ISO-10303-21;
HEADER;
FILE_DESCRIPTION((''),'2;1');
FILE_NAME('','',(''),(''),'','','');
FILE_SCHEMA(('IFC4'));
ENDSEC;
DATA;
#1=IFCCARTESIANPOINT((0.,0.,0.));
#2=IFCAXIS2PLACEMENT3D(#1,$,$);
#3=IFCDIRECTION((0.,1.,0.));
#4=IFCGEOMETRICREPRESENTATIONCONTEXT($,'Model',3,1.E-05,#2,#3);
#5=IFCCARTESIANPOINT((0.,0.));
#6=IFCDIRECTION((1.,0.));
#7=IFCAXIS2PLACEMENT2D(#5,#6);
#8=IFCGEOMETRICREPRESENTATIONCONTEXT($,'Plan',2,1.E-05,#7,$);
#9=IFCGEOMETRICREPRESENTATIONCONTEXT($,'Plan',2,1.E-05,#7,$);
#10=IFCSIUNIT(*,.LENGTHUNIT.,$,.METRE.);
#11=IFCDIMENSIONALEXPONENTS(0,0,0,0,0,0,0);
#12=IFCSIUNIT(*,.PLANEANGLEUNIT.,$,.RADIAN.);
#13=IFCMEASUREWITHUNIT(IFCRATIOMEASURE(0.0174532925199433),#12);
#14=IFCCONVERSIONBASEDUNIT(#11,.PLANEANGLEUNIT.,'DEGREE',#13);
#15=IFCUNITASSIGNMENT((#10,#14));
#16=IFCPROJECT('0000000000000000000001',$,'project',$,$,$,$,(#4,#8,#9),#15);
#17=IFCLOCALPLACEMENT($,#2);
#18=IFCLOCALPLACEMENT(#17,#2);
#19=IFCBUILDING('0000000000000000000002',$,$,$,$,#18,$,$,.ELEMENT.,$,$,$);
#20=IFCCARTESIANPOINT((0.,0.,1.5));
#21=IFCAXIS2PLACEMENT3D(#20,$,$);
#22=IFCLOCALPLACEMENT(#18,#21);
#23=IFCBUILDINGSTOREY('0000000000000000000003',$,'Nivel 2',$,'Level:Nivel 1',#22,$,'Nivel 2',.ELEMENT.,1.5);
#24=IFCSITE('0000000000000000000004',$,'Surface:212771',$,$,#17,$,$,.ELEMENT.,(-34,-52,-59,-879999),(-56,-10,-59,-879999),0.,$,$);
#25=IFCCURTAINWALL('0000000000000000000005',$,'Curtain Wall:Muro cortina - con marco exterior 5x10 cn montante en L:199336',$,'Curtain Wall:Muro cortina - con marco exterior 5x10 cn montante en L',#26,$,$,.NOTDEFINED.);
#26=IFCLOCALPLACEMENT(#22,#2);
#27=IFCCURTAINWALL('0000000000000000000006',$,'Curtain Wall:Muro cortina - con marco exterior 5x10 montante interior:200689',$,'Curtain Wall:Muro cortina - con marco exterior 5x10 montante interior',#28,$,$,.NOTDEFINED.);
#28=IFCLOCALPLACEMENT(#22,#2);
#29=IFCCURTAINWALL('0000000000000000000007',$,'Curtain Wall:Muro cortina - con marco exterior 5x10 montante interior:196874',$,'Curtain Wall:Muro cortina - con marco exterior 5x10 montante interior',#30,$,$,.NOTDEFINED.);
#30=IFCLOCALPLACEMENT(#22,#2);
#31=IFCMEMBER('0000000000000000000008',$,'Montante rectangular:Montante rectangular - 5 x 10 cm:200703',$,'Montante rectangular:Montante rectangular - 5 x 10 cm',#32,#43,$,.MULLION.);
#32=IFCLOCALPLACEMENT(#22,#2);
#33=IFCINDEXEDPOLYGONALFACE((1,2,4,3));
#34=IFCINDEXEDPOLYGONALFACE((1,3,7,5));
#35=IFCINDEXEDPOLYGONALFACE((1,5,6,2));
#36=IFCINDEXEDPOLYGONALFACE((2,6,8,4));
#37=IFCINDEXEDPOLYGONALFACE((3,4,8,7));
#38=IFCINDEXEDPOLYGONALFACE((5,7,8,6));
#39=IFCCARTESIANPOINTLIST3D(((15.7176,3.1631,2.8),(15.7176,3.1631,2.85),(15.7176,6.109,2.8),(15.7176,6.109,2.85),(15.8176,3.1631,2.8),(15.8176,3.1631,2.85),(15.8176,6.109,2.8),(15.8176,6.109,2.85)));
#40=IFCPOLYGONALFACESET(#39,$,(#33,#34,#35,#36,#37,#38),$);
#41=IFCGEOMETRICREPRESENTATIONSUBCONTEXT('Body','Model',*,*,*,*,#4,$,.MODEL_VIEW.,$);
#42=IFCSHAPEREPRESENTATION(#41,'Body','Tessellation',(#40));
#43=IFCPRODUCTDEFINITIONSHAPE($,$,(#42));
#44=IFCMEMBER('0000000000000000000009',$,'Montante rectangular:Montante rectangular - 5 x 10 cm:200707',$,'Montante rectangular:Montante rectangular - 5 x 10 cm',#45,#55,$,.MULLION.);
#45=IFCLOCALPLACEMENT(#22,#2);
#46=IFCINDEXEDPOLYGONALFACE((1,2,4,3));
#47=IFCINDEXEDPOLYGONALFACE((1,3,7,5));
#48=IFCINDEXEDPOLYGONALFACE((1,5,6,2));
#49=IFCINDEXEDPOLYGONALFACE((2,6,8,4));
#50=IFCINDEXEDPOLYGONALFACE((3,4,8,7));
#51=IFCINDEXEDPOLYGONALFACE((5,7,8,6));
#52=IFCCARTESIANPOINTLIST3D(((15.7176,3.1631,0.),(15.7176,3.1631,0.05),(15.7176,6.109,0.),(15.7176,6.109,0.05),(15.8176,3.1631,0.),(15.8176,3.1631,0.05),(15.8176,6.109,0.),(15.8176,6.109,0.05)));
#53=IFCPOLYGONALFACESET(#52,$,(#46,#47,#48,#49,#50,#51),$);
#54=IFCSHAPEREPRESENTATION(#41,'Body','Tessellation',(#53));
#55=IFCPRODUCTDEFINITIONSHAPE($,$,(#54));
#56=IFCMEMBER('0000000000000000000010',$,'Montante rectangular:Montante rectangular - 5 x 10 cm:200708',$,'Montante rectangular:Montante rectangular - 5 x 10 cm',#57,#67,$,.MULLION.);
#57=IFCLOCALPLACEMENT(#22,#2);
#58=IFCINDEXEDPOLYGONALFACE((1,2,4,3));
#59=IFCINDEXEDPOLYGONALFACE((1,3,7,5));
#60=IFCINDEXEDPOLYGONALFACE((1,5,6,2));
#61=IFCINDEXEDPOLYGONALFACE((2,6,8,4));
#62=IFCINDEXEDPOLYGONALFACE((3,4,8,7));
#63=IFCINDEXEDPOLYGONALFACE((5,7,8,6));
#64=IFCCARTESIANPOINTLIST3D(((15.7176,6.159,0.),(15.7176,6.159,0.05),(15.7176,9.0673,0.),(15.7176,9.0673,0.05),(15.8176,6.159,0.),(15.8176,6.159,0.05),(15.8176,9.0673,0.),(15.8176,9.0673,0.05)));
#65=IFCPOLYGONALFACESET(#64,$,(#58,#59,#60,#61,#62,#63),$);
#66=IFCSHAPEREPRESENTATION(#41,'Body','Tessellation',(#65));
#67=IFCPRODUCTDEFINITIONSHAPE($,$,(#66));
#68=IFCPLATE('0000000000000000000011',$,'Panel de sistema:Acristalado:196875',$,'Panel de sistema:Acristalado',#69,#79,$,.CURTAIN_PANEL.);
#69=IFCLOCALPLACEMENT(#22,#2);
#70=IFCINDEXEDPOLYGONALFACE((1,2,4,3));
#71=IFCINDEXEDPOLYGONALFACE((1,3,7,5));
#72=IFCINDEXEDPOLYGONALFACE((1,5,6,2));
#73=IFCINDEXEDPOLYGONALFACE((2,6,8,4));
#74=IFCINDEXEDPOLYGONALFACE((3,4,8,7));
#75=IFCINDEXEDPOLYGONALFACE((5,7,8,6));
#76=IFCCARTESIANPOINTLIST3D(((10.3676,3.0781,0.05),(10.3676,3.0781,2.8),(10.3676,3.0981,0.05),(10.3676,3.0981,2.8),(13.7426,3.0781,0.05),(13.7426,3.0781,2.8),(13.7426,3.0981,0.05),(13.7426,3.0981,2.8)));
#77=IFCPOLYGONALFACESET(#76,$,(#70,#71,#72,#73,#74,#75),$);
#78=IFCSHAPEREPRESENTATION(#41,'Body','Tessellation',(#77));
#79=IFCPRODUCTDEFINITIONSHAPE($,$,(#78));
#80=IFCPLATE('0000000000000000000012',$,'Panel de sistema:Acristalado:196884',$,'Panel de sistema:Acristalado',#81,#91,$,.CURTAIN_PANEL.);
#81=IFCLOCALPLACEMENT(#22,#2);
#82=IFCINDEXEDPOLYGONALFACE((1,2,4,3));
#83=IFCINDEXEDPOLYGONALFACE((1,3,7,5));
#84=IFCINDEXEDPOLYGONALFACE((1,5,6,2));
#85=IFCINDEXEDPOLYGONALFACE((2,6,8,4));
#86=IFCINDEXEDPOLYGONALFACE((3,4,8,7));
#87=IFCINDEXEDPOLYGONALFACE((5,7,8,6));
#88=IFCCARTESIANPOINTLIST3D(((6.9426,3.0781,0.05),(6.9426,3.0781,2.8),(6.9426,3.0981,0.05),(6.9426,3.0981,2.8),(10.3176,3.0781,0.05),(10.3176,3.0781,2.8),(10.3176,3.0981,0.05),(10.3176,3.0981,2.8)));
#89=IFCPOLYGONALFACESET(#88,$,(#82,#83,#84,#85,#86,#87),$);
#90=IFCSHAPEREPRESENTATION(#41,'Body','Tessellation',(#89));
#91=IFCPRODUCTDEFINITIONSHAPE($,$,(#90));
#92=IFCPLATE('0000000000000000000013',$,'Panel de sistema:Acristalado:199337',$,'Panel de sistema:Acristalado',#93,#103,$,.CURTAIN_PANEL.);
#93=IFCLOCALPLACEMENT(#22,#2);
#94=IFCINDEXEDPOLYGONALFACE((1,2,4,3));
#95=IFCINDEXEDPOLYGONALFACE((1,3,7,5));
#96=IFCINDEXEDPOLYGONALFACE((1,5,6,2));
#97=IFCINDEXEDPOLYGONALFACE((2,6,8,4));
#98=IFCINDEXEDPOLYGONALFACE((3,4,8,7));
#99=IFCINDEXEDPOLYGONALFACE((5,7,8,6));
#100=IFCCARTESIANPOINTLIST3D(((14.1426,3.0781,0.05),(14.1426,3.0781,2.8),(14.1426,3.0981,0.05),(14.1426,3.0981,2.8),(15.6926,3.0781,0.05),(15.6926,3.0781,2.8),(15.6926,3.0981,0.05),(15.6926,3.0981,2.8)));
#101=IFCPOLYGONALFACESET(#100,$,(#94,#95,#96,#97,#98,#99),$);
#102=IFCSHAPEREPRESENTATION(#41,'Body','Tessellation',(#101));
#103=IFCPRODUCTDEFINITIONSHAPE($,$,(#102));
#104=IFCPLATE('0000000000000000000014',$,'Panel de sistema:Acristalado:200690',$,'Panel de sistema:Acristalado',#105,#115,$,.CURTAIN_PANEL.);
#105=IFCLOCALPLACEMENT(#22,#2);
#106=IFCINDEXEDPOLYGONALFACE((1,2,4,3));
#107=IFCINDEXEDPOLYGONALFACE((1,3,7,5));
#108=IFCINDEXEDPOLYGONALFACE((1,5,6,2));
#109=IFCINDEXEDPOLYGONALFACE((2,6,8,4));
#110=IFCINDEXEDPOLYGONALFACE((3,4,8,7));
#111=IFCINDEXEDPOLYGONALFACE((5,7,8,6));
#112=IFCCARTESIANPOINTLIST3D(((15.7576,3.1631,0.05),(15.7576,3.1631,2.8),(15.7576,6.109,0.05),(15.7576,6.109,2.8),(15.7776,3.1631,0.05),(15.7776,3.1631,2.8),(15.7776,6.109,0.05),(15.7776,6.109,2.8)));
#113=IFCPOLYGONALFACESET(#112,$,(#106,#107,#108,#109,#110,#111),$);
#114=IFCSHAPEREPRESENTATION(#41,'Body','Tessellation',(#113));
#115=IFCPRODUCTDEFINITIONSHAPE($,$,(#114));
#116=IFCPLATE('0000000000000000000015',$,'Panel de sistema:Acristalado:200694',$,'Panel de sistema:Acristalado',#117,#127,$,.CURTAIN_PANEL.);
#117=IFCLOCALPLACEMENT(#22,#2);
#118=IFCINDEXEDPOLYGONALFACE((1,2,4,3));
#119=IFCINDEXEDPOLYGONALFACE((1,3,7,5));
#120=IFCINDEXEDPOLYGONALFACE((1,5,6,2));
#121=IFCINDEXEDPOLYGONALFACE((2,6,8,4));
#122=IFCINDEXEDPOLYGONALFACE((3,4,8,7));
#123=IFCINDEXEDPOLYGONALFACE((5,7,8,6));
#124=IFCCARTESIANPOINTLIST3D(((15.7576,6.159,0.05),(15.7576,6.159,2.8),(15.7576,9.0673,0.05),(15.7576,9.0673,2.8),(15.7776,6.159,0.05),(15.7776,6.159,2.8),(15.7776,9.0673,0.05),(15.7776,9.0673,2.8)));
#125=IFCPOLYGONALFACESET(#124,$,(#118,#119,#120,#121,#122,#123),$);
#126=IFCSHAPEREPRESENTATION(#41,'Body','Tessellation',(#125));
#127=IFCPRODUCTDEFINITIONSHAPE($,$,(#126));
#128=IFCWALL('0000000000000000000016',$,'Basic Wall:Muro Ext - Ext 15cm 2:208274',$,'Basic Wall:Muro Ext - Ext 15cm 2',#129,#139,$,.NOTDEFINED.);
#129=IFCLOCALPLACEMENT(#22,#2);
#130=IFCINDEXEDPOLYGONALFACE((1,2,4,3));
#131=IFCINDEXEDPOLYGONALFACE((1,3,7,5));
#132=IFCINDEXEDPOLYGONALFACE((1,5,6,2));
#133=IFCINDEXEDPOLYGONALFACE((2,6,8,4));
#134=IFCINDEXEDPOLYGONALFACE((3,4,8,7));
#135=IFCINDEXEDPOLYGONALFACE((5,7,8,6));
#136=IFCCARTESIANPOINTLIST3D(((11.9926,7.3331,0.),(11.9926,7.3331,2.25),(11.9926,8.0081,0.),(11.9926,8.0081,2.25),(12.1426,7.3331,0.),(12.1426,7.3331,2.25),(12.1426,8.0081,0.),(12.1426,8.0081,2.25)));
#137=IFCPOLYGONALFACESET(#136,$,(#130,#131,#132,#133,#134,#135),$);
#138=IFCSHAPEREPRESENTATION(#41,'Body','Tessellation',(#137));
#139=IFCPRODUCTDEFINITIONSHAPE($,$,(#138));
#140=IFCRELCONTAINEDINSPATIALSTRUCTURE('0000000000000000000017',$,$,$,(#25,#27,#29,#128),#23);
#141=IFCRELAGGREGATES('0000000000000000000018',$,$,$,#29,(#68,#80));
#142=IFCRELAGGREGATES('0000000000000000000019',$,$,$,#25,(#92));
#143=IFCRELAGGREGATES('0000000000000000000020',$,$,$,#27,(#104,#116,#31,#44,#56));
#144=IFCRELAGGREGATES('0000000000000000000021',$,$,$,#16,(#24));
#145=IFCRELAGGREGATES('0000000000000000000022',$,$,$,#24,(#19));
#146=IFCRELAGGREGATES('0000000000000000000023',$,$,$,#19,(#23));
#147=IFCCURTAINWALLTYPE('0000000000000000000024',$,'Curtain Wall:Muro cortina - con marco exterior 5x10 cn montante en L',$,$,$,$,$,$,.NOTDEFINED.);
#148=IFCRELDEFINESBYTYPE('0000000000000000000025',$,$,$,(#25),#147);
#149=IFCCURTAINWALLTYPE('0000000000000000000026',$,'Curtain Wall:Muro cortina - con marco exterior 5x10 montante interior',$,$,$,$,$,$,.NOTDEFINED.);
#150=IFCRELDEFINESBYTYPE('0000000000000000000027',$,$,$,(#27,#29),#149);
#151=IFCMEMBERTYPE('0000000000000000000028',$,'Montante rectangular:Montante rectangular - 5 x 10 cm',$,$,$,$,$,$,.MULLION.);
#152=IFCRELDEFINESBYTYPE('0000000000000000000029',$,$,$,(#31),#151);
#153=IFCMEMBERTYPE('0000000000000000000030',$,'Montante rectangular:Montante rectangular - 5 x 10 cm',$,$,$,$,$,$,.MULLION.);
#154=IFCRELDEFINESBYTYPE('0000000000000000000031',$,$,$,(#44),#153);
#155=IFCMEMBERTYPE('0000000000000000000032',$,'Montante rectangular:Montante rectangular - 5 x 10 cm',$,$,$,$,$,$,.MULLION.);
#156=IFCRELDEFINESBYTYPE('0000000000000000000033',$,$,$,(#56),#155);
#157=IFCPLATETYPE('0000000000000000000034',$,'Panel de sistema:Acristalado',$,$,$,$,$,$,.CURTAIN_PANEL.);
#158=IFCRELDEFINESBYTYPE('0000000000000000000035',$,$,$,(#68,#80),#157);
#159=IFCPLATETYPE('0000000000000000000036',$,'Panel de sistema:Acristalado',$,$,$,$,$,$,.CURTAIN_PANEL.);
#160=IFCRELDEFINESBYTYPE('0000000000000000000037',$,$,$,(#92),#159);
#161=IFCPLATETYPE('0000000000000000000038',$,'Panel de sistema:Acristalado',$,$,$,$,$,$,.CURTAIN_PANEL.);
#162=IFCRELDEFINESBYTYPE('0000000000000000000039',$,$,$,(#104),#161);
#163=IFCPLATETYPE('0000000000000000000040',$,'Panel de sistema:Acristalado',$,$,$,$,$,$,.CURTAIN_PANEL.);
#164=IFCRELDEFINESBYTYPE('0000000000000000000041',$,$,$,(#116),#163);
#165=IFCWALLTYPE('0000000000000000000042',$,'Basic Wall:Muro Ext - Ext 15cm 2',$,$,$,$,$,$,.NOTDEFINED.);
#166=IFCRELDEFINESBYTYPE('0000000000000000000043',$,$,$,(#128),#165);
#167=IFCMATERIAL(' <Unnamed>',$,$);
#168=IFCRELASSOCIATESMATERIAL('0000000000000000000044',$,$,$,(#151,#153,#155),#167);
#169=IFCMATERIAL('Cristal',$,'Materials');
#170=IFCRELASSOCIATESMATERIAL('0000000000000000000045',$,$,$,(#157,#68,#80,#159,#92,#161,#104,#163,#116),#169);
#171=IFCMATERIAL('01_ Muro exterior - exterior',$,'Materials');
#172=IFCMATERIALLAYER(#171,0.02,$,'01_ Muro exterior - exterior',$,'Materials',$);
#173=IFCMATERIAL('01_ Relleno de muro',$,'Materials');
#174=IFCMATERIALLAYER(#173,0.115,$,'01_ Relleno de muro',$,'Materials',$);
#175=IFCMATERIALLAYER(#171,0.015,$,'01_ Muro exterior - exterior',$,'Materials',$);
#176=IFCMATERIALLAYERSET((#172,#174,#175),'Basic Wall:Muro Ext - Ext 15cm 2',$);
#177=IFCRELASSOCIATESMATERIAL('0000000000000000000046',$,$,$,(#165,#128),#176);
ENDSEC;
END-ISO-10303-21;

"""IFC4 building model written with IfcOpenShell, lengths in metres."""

from ifc_helpers import new_model, entity, si_unit, converted_unit, direction, frame, origin, origin_2d_with_axis, place, context, subcontext, project, spatial, indexed_curve, outline, extrude, shape, source, transform, mapped, material, layer, layer_set, type_object, type_shapes, element, aggregate, save


model = new_model("IFC4")

# Units and contexts
model_context = context("Model", 3, precision=1e-05, world=origin(), true_north=direction((0.0, 1.0, 0.0)))
plan_context_1 = context("Plan", 2, precision=1e-05, world=origin_2d_with_axis())
plan_context_2 = context("Plan", 2, precision=1e-05, world=origin_2d_with_axis())
body_context = subcontext(model_context, "Body", "Model", "MODEL_VIEW")
footprint_context = subcontext(model_context, "FootPrint", "Model", "MODEL_VIEW")
ifc_project = project(units=[si_unit("LENGTHUNIT", "METRE"), converted_unit("PLANEANGLEUNIT", "DEGREE", entity("IfcRatioMeasure", 0.0174532925199433), si_unit("PLANEANGLEUNIT", "RADIAN"), dimensions=[0, 0, 0, 0, 0, 0, 0])], contexts=[model_context, plan_context_1, plan_context_2])

# Site, building, storey
site_placement = place(None, origin())
site = spatial("IfcSite", under=ifc_project, at=site_placement, Name="Surface:212771", CompositionType="ELEMENT", RefLatitude=(-34, -52, -59, -879999), RefLongitude=(-56, -10, -59, -879999), RefElevation=0.0)
building_placement = place(site_placement, origin())
building = spatial("IfcBuilding", under=site, at=building_placement, CompositionType="ELEMENT")
storey_placement = place(building_placement, frame((0.0, 0.0, 1.5)))
storey = spatial("IfcBuildingStorey", under=building, at=storey_placement, Name="Nivel 2", ObjectType="Level:Nivel 1", LongName="Nivel 2", CompositionType="ELEMENT", Elevation=1.5)

# Curtain walls
curtain_wall_type_1 = type_object("IfcCurtainWallType", Name="Curtain Wall:Muro cortina - con marco exterior 5x10 cn montante en L", PredefinedType="NOTDEFINED")
curtain_wall_1_placement = place(storey_placement, frame((0.0, 0.0, -1.5)))
curtain_wall_1 = element("IfcCurtainWall", 1, at=curtain_wall_1_placement, inside=storey, type_object=curtain_wall_type_1, Name="Curtain Wall:Muro cortina - con marco exterior 5x10 cn montante en L:199336", ObjectType="Curtain Wall:Muro cortina - con marco exterior 5x10 cn montante en L", PredefinedType="NOTDEFINED")
ifc_material_1 = material(Name=" <Unnamed>")
curtain_wall_type_2 = type_object("IfcCurtainWallType", Name="Curtain Wall:Muro cortina - con marco exterior 5x10 montante interior", PredefinedType="NOTDEFINED")
curtain_wall_2_placement = place(storey_placement, frame((0.0, 0.0, -1.5)))
curtain_wall_2 = element("IfcCurtainWall", 2, at=curtain_wall_2_placement, inside=storey, type_object=curtain_wall_type_2, Name="Curtain Wall:Muro cortina - con marco exterior 5x10 montante interior:200689", ObjectType="Curtain Wall:Muro cortina - con marco exterior 5x10 montante interior", PredefinedType="NOTDEFINED")

# Curtain wall
curtain_wall_3_placement = place(storey_placement, frame((0.0, 0.0, -1.5)))
curtain_wall_3 = element("IfcCurtainWall", 3, at=curtain_wall_3_placement, inside=storey, type_object=curtain_wall_type_2, Name="Curtain Wall:Muro cortina - con marco exterior 5x10 montante interior:196874", ObjectType="Curtain Wall:Muro cortina - con marco exterior 5x10 montante interior", PredefinedType="NOTDEFINED")

# Members
member_type_1 = type_object("IfcMemberType", Name="Montante rectangular:Montante rectangular - 5 x 10 cm", PredefinedType="MULLION", material=ifc_material_1)
shared_shape_1 = source(origin(), body_context, "Body", "SweptSolid", [
    extrude(outline(indexed_curve([(-0.05, -0.025), (0.05, -0.025), (0.05, 0.025), (-0.05, 0.025), (-0.05, -0.025)], self_intersect=False)), frame((-0.025, 0.0, -2.9458), z_axis=(0.0, 0.0, 1.0), x_axis=(0.0, -1.0, 0.0)), (0.0, 0.0, 1.0), 2.9458),
])
type_shapes(member_type_1, [shared_shape_1])
member_1_placement = place(storey_placement, frame((15.7676, 6.109, 2.85), z_axis=(0.0, 1.0, 0.0), x_axis=(0.0, 0.0, 1.0)))
member_1 = element("IfcMember", 4, at=member_1_placement, type_object=member_type_1, Name="Montante rectangular:Montante rectangular - 5 x 10 cm:200703", ObjectType="Montante rectangular:Montante rectangular - 5 x 10 cm", PredefinedType="MULLION", context=body_context, shape_type="MappedRepresentation", body=[
    mapped(shared_shape_1, transform((0.0, 0.0, 0.0), scale=1.0)),
])
member_type_2 = type_object("IfcMemberType", Name="Montante rectangular:Montante rectangular - 5 x 10 cm", PredefinedType="MULLION", material=ifc_material_1)
shared_shape_2 = source(origin(), body_context, "Body", "SweptSolid", [
    extrude(outline(indexed_curve([(-0.05, -0.025), (0.05, -0.025), (0.05, 0.025), (-0.05, 0.025), (-0.05, -0.025)], self_intersect=False)), frame((-0.025, 0.0, -2.9458), z_axis=(0.0, 0.0, 1.0), x_axis=(0.0, -1.0, 0.0)), (0.0, 0.0, 1.0), 2.9458),
])
type_shapes(member_type_2, [shared_shape_2])
member_2_placement = place(storey_placement, frame((15.7676, 3.1631, 0.0), z_axis=(0.0, -1.0, 0.0), x_axis=(0.0, 0.0, -1.0)))
member_2 = element("IfcMember", 5, at=member_2_placement, type_object=member_type_2, Name="Montante rectangular:Montante rectangular - 5 x 10 cm:200707", ObjectType="Montante rectangular:Montante rectangular - 5 x 10 cm", PredefinedType="MULLION", context=body_context, shape_type="MappedRepresentation", body=[
    mapped(shared_shape_2, transform((0.0, 0.0, 0.0), scale=1.0)),
])
member_type_3 = type_object("IfcMemberType", Name="Montante rectangular:Montante rectangular - 5 x 10 cm", PredefinedType="MULLION", material=ifc_material_1)
shared_shape_3 = source(origin(), body_context, "Body", "SweptSolid", [
    extrude(outline(indexed_curve([(-0.05, -0.025), (0.05, -0.025), (0.05, 0.025), (-0.05, 0.025), (-0.05, -0.025)], self_intersect=False)), frame((-0.025, 0.0, -2.9083), z_axis=(0.0, 0.0, 1.0), x_axis=(0.0, -1.0, 0.0)), (0.0, 0.0, 1.0), 2.9083),
])
type_shapes(member_type_3, [shared_shape_3])
member_3_placement = place(storey_placement, frame((15.7676, 6.159, 0.0), z_axis=(0.0, -1.0, 0.0), x_axis=(0.0, 0.0, -1.0)))
member_3 = element("IfcMember", 6, at=member_3_placement, type_object=member_type_3, Name="Montante rectangular:Montante rectangular - 5 x 10 cm:200708", ObjectType="Montante rectangular:Montante rectangular - 5 x 10 cm", PredefinedType="MULLION", context=body_context, shape_type="MappedRepresentation", body=[
    mapped(shared_shape_3, transform((0.0, 0.0, 0.0), scale=1.0)),
])

# Plates
ifc_material_2 = material(Name="Cristal", Category="Materials")
plate_type_1 = type_object("IfcPlateType", Name="Panel de sistema:Acristalado", PredefinedType="CURTAIN_PANEL", material=ifc_material_2)
shared_shape_4 = source(origin(), body_context, "Body", "SweptSolid", [
    extrude(outline(indexed_curve([(-0.01, -1.6875), (0.01, -1.6875), (0.01, 1.6875), (-0.01, 1.6875), (-0.01, -1.6875)], self_intersect=False)), frame((0.0, 0.0, 0.0), z_axis=(0.0, 0.0, 1.0), x_axis=(0.0, 1.0, 0.0)), (0.0, 0.0, 1.0), 2.75),
])
shared_shape_5 = source(origin(), footprint_context, "FootPrint", "Curve2D", [
    entity("IfcIndexedPolyCurve", entity("IfcCartesianPointList2D", [[1.6875, -0.01], [1.6875, 0.01], [-1.6875, 0.01], [-1.6875, -0.01], [1.6875, -0.01]]), None, False),
])
type_shapes(plate_type_1, [shared_shape_4, shared_shape_5])
plate_1_placement = place(curtain_wall_3_placement, frame((12.0551, 3.0881, 1.55), z_axis=(0.0, 0.0, 1.0), x_axis=(-1.0, 0.0, 0.0)))
plate_1 = element("IfcPlate", 7, at=plate_1_placement, type_object=plate_type_1, material=ifc_material_2, Name="Panel de sistema:Acristalado:196875", ObjectType="Panel de sistema:Acristalado", PredefinedType="CURTAIN_PANEL", shapes=[
    shape(body_context, "Body", "MappedRepresentation", [mapped(shared_shape_4, transform((0.0, 0.0, 0.0), scale=1.0))]),
    shape(body_context, "Body", "MappedRepresentation", [mapped(shared_shape_5, transform((0.0, 0.0, 0.0), scale=1.0))]),
])
plate_2_placement = place(curtain_wall_3_placement, frame((8.6301, 3.0881, 1.55), z_axis=(0.0, 0.0, 1.0), x_axis=(-1.0, 0.0, 0.0)))
plate_2 = element("IfcPlate", 8, at=plate_2_placement, type_object=plate_type_1, material=ifc_material_2, Name="Panel de sistema:Acristalado:196884", ObjectType="Panel de sistema:Acristalado", PredefinedType="CURTAIN_PANEL", shapes=[
    shape(body_context, "Body", "MappedRepresentation", [mapped(shared_shape_4, transform((0.0, 0.0, 0.0), scale=1.0))]),
    shape(body_context, "Body", "MappedRepresentation", [mapped(shared_shape_5, transform((0.0, 0.0, 0.0), scale=1.0))]),
])
aggregate(curtain_wall_3, [plate_1, plate_2])
plate_type_2 = type_object("IfcPlateType", Name="Panel de sistema:Acristalado", PredefinedType="CURTAIN_PANEL", material=ifc_material_2)
shared_shape_6 = source(origin(), body_context, "Body", "SweptSolid", [
    extrude(outline(indexed_curve([(-0.01, -0.775), (0.01, -0.775), (0.01, 0.775), (-0.01, 0.775), (-0.01, -0.775)], self_intersect=False)), frame((0.0, 0.0, 0.0), z_axis=(0.0, 0.0, 1.0), x_axis=(0.0, 1.0, 0.0)), (0.0, 0.0, 1.0), 2.75),
])
shared_shape_7 = source(origin(), footprint_context, "FootPrint", "Curve2D", [
    entity("IfcIndexedPolyCurve", entity("IfcCartesianPointList2D", [[0.775, -0.01], [0.775, 0.01], [-0.775, 0.01], [-0.775, -0.01], [0.775, -0.01]]), None, False),
])
type_shapes(plate_type_2, [shared_shape_6, shared_shape_7])
plate_3_placement = place(curtain_wall_1_placement, frame((14.9176, 3.0881, 1.55)))
plate_3 = element("IfcPlate", 9, at=plate_3_placement, type_object=plate_type_2, material=ifc_material_2, Name="Panel de sistema:Acristalado:199337", ObjectType="Panel de sistema:Acristalado", PredefinedType="CURTAIN_PANEL", shapes=[
    shape(body_context, "Body", "MappedRepresentation", [mapped(shared_shape_6, transform((0.0, 0.0, 0.0), scale=1.0))]),
    shape(body_context, "Body", "MappedRepresentation", [mapped(shared_shape_7, transform((0.0, 0.0, 0.0), scale=1.0))]),
])
aggregate(curtain_wall_1, [plate_3])
plate_type_3 = type_object("IfcPlateType", Name="Panel de sistema:Acristalado", PredefinedType="CURTAIN_PANEL", material=ifc_material_2)
shared_shape_8 = source(origin(), body_context, "Body", "SweptSolid", [
    extrude(outline(indexed_curve([(-0.01, -1.4729), (0.01, -1.4729), (0.01, 1.4729), (-0.01, 1.4729), (-0.01, -1.4729)], self_intersect=False)), frame((0.0, 0.0, 0.0), z_axis=(0.0, 0.0, 1.0), x_axis=(0.0, 1.0, 0.0)), (0.0, 0.0, 1.0), 2.75),
])
shared_shape_9 = source(origin(), footprint_context, "FootPrint", "Curve2D", [
    entity("IfcIndexedPolyCurve", entity("IfcCartesianPointList2D", [[1.4729, -0.01], [1.4729, 0.01], [-1.4729, 0.01], [-1.4729, -0.01], [1.4729, -0.01]]), None, False),
])
type_shapes(plate_type_3, [shared_shape_8, shared_shape_9])
plate_4_placement = place(curtain_wall_2_placement, frame((15.7676, 4.6361, 1.55), z_axis=(0.0, 0.0, 1.0), x_axis=(0.0, 1.0, 0.0)))
plate_4 = element("IfcPlate", 10, at=plate_4_placement, type_object=plate_type_3, material=ifc_material_2, Name="Panel de sistema:Acristalado:200690", ObjectType="Panel de sistema:Acristalado", PredefinedType="CURTAIN_PANEL", shapes=[
    shape(body_context, "Body", "MappedRepresentation", [mapped(shared_shape_8, transform((0.0, 0.0, 0.0), scale=1.0))]),
    shape(body_context, "Body", "MappedRepresentation", [mapped(shared_shape_9, transform((0.0, 0.0, 0.0), scale=1.0))]),
])
plate_type_4 = type_object("IfcPlateType", Name="Panel de sistema:Acristalado", PredefinedType="CURTAIN_PANEL", material=ifc_material_2)
shared_shape_10 = source(origin(), body_context, "Body", "SweptSolid", [
    extrude(outline(indexed_curve([(-0.01, -1.4542), (0.01, -1.4542), (0.01, 1.4542), (-0.01, 1.4542), (-0.01, -1.4542)], self_intersect=False)), frame((0.0, 0.0, 0.0), z_axis=(0.0, 0.0, 1.0), x_axis=(0.0, 1.0, 0.0)), (0.0, 0.0, 1.0), 2.75),
])
shared_shape_11 = source(origin(), footprint_context, "FootPrint", "Curve2D", [
    entity("IfcIndexedPolyCurve", entity("IfcCartesianPointList2D", [[1.4542, -0.01], [1.4542, 0.01], [-1.4542, 0.01], [-1.4542, -0.01], [1.4542, -0.01]]), None, False),
])
type_shapes(plate_type_4, [shared_shape_10, shared_shape_11])
plate_5_placement = place(curtain_wall_2_placement, frame((15.7676, 7.6131, 1.55), z_axis=(0.0, 0.0, 1.0), x_axis=(0.0, 1.0, 0.0)))
plate_5 = element("IfcPlate", 11, at=plate_5_placement, type_object=plate_type_4, material=ifc_material_2, Name="Panel de sistema:Acristalado:200694", ObjectType="Panel de sistema:Acristalado", PredefinedType="CURTAIN_PANEL", shapes=[
    shape(body_context, "Body", "MappedRepresentation", [mapped(shared_shape_10, transform((0.0, 0.0, 0.0), scale=1.0))]),
    shape(body_context, "Body", "MappedRepresentation", [mapped(shared_shape_11, transform((0.0, 0.0, 0.0), scale=1.0))]),
])
aggregate(curtain_wall_2, [plate_4, plate_5, member_1, member_2, member_3])

# Wall
ifc_material_3 = material(Name="01_ Muro exterior - exterior", Category="Materials")
ifc_layer_1 = layer(ifc_material_3, 0.02, Name="01_ Muro exterior - exterior", Category="Materials")
ifc_material_4 = material(Name="01_ Relleno de muro", Category="Materials")
ifc_layer_2 = layer(ifc_material_4, 0.115, Name="01_ Relleno de muro", Category="Materials")
ifc_layer_3 = layer(ifc_material_3, 0.015, Name="01_ Muro exterior - exterior", Category="Materials")
ifc_layer_set = layer_set([ifc_layer_1, ifc_layer_2, ifc_layer_3], Name="Basic Wall:Muro Ext - Ext 15cm 2")
wall_type = type_object("IfcWallType", Name="Basic Wall:Muro Ext - Ext 15cm 2", PredefinedType="NOTDEFINED", material=ifc_layer_set)
wall_placement = place(storey_placement, frame((12.0676, 8.0081, 0.0), z_axis=(0.0, 0.0, 1.0), x_axis=(0.0, -1.0, 0.0)))
element("IfcWall", 12, at=wall_placement, inside=storey, type_object=wall_type, material=ifc_layer_set, Name="Basic Wall:Muro Ext - Ext 15cm 2:208274", ObjectType="Basic Wall:Muro Ext - Ext 15cm 2", PredefinedType="NOTDEFINED", context=body_context, shape_type="SweptSolid", body=[
    extrude(outline(indexed_curve([(0.675, 0.075), (0.0, 0.075), (0.0, -0.075), (0.675, -0.075), (0.675, 0.075)], self_intersect=False)), origin(), (0.0, 0.0, 1.0), 2.25),
])

save(model, "model.ifc")
